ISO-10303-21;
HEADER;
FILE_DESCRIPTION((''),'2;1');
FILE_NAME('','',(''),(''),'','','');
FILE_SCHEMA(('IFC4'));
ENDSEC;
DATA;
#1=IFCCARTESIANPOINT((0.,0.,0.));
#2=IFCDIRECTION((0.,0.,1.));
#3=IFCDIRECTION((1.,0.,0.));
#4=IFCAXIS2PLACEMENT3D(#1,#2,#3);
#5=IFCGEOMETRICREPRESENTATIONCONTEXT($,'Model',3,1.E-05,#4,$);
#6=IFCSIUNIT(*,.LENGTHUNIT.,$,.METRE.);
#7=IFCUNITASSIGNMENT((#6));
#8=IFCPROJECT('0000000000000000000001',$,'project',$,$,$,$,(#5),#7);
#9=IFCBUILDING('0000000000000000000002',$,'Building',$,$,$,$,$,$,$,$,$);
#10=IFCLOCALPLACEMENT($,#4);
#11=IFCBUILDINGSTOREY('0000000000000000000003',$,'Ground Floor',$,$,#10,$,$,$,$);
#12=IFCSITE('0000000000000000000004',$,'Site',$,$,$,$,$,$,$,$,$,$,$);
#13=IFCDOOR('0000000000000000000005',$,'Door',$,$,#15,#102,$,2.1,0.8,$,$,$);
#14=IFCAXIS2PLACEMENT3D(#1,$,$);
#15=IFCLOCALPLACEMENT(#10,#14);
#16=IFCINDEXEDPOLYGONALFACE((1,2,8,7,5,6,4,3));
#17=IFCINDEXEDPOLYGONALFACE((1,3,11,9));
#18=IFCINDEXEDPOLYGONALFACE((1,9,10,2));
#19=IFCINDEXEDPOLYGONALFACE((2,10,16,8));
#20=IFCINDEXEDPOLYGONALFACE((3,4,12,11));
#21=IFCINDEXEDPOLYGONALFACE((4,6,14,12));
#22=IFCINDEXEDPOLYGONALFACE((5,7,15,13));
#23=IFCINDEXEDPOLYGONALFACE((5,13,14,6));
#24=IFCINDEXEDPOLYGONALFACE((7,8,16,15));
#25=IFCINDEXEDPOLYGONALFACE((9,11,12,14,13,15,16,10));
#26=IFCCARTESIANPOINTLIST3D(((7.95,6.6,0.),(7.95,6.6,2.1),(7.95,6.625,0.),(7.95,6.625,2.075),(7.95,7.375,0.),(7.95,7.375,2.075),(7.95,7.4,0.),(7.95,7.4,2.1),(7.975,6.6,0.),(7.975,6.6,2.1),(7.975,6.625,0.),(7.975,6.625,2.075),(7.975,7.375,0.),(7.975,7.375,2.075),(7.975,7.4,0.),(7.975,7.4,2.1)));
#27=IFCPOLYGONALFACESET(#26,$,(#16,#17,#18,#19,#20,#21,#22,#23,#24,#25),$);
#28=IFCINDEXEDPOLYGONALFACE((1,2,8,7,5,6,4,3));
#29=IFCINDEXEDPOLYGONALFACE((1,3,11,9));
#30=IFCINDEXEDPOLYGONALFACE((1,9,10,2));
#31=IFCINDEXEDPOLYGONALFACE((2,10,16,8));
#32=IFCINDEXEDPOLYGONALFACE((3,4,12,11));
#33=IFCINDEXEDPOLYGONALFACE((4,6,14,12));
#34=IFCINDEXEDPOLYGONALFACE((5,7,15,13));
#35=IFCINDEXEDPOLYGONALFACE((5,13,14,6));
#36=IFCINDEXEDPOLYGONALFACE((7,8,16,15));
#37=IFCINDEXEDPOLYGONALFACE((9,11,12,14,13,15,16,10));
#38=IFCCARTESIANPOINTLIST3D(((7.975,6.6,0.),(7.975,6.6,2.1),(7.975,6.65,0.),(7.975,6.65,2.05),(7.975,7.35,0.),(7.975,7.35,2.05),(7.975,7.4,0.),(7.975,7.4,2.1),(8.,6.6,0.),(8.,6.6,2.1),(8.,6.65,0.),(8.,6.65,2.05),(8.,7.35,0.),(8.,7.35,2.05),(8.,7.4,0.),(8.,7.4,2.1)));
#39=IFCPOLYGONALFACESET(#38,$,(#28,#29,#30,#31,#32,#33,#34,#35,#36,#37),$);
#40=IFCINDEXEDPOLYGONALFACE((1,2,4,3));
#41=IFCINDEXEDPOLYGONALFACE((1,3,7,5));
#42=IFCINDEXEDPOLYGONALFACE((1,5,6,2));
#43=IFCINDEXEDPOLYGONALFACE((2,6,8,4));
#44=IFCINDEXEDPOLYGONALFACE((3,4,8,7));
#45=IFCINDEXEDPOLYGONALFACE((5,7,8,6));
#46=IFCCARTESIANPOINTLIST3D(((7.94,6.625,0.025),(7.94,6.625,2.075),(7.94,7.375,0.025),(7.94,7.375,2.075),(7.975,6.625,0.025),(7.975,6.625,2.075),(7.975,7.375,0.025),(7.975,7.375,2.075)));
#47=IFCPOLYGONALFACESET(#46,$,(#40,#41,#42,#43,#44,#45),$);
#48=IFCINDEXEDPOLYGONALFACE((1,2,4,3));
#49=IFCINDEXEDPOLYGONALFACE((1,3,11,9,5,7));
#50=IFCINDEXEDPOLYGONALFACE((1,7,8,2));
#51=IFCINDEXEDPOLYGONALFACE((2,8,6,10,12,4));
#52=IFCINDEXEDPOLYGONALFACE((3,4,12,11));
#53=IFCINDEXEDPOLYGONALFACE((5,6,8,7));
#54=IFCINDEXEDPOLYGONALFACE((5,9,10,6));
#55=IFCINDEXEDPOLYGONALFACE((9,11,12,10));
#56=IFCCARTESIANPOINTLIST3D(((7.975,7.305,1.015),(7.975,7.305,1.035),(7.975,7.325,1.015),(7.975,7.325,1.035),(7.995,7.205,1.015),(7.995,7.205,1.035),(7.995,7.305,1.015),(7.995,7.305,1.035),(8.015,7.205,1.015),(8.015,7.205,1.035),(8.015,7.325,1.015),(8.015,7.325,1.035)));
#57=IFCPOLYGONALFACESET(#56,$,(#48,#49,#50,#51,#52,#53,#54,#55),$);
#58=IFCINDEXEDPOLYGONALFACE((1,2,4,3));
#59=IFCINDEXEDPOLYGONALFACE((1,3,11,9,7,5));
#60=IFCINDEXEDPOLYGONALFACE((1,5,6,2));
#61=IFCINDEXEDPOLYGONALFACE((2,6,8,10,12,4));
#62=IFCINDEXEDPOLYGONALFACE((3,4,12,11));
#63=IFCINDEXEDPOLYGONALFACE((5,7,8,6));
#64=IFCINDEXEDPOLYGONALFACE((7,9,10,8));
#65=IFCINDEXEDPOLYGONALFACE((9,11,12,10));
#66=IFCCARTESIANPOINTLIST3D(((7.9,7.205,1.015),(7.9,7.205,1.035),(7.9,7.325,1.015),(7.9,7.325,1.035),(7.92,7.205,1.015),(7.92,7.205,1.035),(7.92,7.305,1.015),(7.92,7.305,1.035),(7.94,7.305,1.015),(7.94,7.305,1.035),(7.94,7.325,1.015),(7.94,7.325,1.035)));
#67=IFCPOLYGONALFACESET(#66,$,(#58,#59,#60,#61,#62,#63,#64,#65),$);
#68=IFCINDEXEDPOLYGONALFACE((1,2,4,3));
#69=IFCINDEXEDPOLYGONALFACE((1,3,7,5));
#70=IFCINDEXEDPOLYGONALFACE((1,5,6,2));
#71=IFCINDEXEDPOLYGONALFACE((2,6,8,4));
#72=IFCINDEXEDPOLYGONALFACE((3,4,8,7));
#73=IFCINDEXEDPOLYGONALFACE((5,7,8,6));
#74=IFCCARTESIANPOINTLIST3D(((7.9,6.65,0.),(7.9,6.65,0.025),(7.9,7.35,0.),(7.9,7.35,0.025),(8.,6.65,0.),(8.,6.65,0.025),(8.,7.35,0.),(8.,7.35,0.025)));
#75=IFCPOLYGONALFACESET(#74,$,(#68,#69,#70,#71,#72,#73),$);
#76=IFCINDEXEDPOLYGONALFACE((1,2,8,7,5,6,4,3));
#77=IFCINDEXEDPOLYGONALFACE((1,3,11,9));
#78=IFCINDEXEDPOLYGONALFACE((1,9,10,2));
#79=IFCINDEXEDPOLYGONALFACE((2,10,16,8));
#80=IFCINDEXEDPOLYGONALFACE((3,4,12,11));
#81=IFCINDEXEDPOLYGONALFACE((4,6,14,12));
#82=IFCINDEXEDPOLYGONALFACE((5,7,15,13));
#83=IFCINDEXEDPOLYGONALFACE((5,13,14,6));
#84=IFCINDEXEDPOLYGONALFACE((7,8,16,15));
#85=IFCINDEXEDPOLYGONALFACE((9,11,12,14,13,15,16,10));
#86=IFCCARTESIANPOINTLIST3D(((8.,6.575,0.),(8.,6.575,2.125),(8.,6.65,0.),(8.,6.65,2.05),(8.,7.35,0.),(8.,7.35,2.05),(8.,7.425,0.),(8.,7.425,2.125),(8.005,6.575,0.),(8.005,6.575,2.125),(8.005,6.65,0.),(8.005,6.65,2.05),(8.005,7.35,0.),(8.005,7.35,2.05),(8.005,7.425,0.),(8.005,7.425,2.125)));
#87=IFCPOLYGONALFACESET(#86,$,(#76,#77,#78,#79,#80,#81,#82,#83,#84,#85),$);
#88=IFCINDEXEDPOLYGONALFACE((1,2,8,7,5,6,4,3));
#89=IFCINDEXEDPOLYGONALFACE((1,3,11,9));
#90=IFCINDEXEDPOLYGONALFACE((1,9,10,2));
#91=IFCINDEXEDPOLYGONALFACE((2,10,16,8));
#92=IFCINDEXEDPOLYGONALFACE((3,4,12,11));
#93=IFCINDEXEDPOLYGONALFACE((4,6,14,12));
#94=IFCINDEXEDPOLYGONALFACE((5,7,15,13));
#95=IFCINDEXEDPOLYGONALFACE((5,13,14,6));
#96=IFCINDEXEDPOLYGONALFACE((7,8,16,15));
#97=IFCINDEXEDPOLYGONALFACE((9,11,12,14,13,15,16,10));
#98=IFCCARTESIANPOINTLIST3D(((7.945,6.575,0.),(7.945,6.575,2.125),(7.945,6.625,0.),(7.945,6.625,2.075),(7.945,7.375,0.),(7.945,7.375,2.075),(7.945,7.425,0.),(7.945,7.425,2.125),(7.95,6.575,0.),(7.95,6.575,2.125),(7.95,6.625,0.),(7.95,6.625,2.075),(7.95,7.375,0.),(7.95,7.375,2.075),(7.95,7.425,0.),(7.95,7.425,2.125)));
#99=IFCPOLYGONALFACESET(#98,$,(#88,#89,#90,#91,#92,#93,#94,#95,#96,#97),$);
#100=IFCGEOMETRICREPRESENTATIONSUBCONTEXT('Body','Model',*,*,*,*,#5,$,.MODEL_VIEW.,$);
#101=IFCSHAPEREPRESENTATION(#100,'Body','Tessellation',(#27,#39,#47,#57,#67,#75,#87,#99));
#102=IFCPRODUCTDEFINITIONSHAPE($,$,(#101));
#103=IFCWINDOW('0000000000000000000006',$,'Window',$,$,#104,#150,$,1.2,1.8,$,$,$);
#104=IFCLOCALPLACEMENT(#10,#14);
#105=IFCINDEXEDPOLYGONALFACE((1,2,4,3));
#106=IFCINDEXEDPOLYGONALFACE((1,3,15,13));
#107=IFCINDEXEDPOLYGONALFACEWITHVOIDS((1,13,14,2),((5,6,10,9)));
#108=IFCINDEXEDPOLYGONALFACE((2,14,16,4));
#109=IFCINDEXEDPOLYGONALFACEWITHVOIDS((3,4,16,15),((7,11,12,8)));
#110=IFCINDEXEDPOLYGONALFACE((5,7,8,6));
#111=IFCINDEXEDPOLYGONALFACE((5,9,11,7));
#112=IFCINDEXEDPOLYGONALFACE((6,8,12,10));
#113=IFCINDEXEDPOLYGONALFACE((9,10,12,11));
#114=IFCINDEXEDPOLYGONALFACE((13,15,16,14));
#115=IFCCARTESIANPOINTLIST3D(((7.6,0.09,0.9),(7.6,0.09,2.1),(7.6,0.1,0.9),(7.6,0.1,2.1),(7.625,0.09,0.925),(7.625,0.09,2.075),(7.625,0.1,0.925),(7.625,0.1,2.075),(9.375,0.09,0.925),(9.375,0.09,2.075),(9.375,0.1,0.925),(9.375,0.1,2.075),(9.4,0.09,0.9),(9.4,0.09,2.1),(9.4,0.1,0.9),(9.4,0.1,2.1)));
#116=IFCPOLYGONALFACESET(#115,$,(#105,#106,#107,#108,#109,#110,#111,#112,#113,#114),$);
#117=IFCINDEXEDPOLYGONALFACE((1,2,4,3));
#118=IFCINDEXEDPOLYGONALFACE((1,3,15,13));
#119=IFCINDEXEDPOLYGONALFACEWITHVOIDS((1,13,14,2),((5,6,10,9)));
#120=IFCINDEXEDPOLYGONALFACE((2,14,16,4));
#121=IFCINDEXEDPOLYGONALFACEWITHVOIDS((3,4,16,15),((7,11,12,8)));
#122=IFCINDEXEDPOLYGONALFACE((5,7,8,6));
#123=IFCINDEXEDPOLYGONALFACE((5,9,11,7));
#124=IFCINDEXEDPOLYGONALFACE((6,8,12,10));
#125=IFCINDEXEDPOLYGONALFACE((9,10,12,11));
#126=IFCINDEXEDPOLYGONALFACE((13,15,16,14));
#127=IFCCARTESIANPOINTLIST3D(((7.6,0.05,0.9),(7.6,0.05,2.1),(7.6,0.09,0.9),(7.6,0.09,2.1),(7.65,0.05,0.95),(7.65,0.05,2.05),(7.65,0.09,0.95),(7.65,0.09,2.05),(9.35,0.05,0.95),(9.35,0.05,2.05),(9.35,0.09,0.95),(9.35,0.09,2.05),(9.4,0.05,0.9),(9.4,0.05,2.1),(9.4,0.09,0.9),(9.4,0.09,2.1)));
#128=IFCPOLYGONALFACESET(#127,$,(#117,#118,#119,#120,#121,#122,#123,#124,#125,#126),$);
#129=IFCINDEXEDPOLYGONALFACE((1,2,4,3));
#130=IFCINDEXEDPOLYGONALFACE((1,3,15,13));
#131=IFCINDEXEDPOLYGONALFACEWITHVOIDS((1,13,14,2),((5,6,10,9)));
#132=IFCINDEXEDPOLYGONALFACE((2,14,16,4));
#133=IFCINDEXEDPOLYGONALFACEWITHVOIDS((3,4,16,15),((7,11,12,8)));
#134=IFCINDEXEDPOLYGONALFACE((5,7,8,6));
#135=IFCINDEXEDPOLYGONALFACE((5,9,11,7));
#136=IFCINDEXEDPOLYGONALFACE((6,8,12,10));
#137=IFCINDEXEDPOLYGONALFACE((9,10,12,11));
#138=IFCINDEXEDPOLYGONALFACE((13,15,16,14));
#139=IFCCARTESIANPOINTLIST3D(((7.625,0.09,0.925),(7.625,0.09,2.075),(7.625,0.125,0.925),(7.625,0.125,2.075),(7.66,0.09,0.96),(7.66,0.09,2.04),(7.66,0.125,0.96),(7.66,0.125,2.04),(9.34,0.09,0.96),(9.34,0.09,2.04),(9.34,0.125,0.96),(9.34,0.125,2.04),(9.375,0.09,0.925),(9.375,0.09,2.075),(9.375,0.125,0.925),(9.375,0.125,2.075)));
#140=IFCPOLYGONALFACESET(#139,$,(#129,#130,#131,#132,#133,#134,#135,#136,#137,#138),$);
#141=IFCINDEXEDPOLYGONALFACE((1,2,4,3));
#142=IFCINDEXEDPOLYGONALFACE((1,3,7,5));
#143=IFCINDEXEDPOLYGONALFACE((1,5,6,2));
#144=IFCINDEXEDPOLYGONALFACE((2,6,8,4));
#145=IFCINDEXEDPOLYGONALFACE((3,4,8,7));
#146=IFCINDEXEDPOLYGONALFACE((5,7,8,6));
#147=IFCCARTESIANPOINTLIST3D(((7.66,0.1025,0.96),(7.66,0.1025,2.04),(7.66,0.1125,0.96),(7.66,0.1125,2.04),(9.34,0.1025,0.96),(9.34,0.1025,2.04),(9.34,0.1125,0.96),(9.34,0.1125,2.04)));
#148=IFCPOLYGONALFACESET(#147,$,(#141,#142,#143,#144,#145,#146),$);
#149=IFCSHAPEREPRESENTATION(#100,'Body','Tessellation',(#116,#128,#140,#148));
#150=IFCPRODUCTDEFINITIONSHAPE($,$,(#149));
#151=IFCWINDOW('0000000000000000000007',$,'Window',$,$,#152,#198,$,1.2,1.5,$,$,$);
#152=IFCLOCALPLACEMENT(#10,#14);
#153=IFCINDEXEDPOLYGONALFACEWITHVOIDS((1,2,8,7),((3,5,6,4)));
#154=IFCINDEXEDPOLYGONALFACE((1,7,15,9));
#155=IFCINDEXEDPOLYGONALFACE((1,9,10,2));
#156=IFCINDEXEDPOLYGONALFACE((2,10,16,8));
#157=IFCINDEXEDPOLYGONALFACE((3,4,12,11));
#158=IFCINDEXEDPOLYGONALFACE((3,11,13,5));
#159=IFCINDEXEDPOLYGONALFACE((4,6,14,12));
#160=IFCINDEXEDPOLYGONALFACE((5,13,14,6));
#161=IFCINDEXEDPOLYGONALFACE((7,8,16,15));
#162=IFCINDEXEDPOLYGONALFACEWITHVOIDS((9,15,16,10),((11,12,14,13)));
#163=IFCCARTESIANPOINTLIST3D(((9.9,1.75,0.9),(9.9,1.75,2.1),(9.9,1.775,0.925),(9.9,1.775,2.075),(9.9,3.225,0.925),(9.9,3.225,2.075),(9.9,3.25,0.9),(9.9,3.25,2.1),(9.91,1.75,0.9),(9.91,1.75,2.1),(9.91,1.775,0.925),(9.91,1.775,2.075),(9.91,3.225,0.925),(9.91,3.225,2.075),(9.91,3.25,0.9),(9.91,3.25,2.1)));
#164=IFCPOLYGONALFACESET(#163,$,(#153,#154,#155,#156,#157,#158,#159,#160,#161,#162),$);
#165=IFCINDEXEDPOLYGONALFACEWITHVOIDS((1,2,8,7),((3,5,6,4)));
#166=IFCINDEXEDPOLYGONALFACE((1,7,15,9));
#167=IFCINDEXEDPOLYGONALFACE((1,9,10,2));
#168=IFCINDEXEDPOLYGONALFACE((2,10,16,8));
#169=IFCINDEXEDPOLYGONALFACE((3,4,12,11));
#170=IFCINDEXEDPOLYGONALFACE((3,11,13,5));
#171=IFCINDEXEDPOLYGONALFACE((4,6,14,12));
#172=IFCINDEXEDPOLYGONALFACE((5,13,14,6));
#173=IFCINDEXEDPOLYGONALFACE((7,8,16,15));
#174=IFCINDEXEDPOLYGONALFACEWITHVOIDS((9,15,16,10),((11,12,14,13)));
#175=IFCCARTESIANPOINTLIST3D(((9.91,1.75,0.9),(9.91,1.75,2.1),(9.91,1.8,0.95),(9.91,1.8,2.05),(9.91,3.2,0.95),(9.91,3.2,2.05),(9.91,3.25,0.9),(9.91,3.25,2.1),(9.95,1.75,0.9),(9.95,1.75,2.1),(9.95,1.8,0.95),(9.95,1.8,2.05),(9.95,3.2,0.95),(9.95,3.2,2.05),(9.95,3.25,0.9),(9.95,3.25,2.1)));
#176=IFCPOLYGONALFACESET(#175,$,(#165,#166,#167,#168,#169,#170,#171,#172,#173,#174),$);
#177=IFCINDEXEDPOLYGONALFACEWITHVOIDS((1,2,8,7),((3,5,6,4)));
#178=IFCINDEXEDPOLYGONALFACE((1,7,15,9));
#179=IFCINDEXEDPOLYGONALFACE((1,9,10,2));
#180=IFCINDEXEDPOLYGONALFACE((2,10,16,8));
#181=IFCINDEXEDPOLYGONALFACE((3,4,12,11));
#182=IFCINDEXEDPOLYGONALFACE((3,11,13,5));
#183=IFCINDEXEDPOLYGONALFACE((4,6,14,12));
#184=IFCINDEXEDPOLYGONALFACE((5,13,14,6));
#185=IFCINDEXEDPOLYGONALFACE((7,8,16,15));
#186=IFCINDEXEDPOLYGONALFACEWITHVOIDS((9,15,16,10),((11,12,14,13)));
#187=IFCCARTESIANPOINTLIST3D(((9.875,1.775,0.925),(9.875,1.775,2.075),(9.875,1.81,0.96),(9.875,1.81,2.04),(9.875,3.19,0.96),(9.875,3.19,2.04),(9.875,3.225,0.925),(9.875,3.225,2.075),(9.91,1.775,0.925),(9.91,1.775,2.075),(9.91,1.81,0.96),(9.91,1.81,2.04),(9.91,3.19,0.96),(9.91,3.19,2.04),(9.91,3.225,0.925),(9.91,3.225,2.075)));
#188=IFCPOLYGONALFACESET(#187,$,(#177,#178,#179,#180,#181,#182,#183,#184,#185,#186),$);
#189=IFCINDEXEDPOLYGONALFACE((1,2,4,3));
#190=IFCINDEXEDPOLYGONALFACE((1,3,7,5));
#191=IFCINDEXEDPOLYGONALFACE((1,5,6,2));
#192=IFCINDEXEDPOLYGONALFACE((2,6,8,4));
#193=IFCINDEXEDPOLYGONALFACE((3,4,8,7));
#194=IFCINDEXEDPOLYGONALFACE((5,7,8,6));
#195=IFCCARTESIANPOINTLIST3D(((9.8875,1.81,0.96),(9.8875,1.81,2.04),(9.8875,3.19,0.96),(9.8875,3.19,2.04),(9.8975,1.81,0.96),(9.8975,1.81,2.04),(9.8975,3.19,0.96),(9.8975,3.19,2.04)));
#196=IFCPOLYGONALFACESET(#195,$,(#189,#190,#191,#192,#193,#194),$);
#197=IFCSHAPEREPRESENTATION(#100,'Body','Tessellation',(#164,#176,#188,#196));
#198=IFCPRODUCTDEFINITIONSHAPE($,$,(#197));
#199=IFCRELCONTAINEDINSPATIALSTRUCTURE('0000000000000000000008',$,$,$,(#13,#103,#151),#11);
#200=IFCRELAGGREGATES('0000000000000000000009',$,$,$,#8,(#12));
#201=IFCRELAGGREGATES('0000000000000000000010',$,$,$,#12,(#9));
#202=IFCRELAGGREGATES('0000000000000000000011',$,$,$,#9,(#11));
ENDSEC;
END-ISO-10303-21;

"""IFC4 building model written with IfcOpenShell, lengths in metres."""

from ifc_helpers import new_model, si_unit, frame, origin_with_axes, place, context, subcontext, project, spatial, line, indexed_curve, outline, extrude, element, save


model = new_model("IFC4")

# Units and contexts
model_context = context("Model", 3, precision=1e-05, world=origin_with_axes())
body_context = subcontext(model_context, "Body", "Model", "MODEL_VIEW")
ifc_project = project(units=[si_unit("LENGTHUNIT", "METRE")], contexts=[model_context])

# Site, building, storey
site = spatial("IfcSite", under=ifc_project, Name="Site")
building = spatial("IfcBuilding", under=site, Name="Building")
storey_placement = place(None, origin_with_axes())
storey = spatial("IfcBuildingStorey", under=building, at=storey_placement, Name="Ground Floor")

# Door
door_1_placement = place(storey_placement, frame((8.0, 6.6, 0.0), z_axis=(0.0, 0.0, 1.0), x_axis=(0.0, 1.0, 0.0)))
element("IfcDoor", 1, at=door_1_placement, inside=storey, Name="Door", OverallHeight=2.1, OverallWidth=0.8, context=body_context, shape_type="SweptSolid", body=[
    extrude(outline(indexed_curve([(0.0, 0.0), (0.0, 2.1), (0.8, 2.1), (0.8, 0.0), (0.775, 0.0), (0.775, 2.075), (0.025, 2.075), (0.025, 0.0)], segments=[line(1, 2, 3, 4, 5, 6, 7, 8, 1)])), frame((0.0, 0.025, 0.0), z_axis=(0.0, -1.0, 0.0), x_axis=(1.0, 0.0, 0.0)), (0.0, 0.0, -1.0), 0.025),
    extrude(outline(indexed_curve([(0.0, 0.0), (0.0, 2.1), (0.8, 2.1), (0.8, 0.0), (0.75, 0.0), (0.75, 2.05), (0.05, 2.05), (0.05, 0.0)], segments=[line(1, 2, 3, 4, 5, 6, 7, 8, 1)])), frame((0.0, 0.0, 0.0), z_axis=(0.0, -1.0, 0.0), x_axis=(1.0, 0.0, 0.0)), (0.0, 0.0, -1.0), 0.025),
    extrude(outline(indexed_curve([(0.0, 0.0), (0.75, 0.0), (0.75, 0.035), (0.0, 0.035)], segments=[line(1, 2, 3, 4, 1)])), frame((0.025, 0.025, 0.025), z_axis=(0.0, 0.0, 1.0), x_axis=(1.0, 0.0, 0.0)), (0.0, 0.0, 1.0), 2.05),
    extrude(outline(indexed_curve([(0.0, 0.0), (0.0, -0.04), (-0.12, -0.04), (-0.12, -0.02), (-0.02, -0.02), (-0.02, 0.0)], segments=[line(1, 2, 3, 4, 5, 6, 1)])), frame((0.725, 0.025, 1.015), z_axis=(0.0, 0.0, 1.0), x_axis=(1.0, 0.0, 0.0)), (0.0, 0.0, 1.0), 0.02),
    extrude(outline(indexed_curve([(0.0, 0.0), (0.0, 0.04), (-0.12, 0.04), (-0.12, 0.02), (-0.02, 0.02), (-0.02, 0.0)], segments=[line(1, 2, 3, 4, 5, 6, 1)])), frame((0.725, 0.06, 1.015), z_axis=(0.0, 0.0, 1.0), x_axis=(1.0, 0.0, 0.0)), (0.0, 0.0, 1.0), 0.02),
    extrude(outline(indexed_curve([(0.0, 0.0), (0.7, 0.0), (0.7, 0.1), (0.0, 0.1)], segments=[line(1, 2, 3, 4, 1)])), frame((0.05, 0.0, 0.0), z_axis=(0.0, 0.0, 1.0), x_axis=(1.0, 0.0, 0.0)), (0.0, 0.0, 1.0), 0.025),
    extrude(outline(indexed_curve([(0.0, 0.0), (0.0, 2.125), (0.85, 2.125), (0.85, 0.0), (0.775, 0.0), (0.775, 2.05), (0.075, 2.05), (0.075, 0.0)], segments=[line(1, 2, 3, 4, 5, 6, 7, 8, 1)])), frame((-0.025, -0.005, 0.0), z_axis=(0.0, -1.0, 0.0), x_axis=(1.0, 0.0, 0.0)), (0.0, 0.0, -1.0), 0.005),
    extrude(outline(indexed_curve([(0.0, 0.0), (0.0, 2.125), (0.85, 2.125), (0.85, 0.0), (0.8, 0.0), (0.8, 2.075), (0.05, 2.075), (0.05, 0.0)], segments=[line(1, 2, 3, 4, 5, 6, 7, 8, 1)])), frame((-0.025, 0.05, 0.0), z_axis=(0.0, -1.0, 0.0), x_axis=(1.0, 0.0, 0.0)), (0.0, 0.0, -1.0), 0.005),
])

# Windows
window_1_placement = place(storey_placement, frame((7.6, 0.0, 0.9), z_axis=(0.0, 0.0, 1.0), x_axis=(1.0, 0.0, 0.0)))
element("IfcWindow", 2, at=window_1_placement, inside=storey, Name="Window", OverallHeight=1.2, OverallWidth=1.8, context=body_context, shape_type="SweptSolid", body=[
    extrude(outline(indexed_curve([(0.0, 0.0), (1.8, 0.0), (1.8, 1.2), (0.0, 1.2)], segments=[line(1, 2, 3, 4, 1)]), holes=[indexed_curve([(0.025, 0.025), (1.775, 0.025), (1.775, 1.175), (0.025, 1.175)], segments=[line(1, 2, 3, 4, 1)])]), frame((0.0, 0.09, 0.0), z_axis=(0.0, -1.0, 0.0), x_axis=(1.0, 0.0, 0.0)), (0.0, 0.0, -1.0), 0.01),
    extrude(outline(indexed_curve([(0.0, 0.0), (1.8, 0.0), (1.8, 1.2), (0.0, 1.2)], segments=[line(1, 2, 3, 4, 1)]), holes=[indexed_curve([(0.05, 0.05), (1.75, 0.05), (1.75, 1.15), (0.05, 1.15)], segments=[line(1, 2, 3, 4, 1)])]), frame((0.0, 0.05, 0.0), z_axis=(0.0, -1.0, 0.0), x_axis=(1.0, 0.0, 0.0)), (0.0, 0.0, -1.0), 0.04),
    extrude(outline(indexed_curve([(0.0, 0.0), (1.75, 0.0), (1.75, 1.15), (0.0, 1.15)], segments=[line(1, 2, 3, 4, 1)]), holes=[indexed_curve([(0.035, 0.035), (1.715, 0.035), (1.715, 1.115), (0.035, 1.115)], segments=[line(1, 2, 3, 4, 1)])]), frame((0.025, 0.09, 0.025), z_axis=(0.0, -1.0, 0.0), x_axis=(1.0, 0.0, 0.0)), (0.0, 0.0, -1.0), 0.035),
    extrude(outline(indexed_curve([(0.035, 0.035), (1.715, 0.035), (1.715, 1.115), (0.035, 1.115)], segments=[line(1, 2, 3, 4, 1)])), frame((0.025, 0.1025, 0.025), z_axis=(0.0, -1.0, 0.0), x_axis=(1.0, 0.0, 0.0)), (0.0, 0.0, -1.0), 0.01),
])
window_2_placement = place(storey_placement, frame((10.0, 1.75, 0.9), z_axis=(0.0, 0.0, 1.0), x_axis=(0.0, 1.0, 0.0)))
element("IfcWindow", 3, at=window_2_placement, inside=storey, Name="Window", OverallHeight=1.2, OverallWidth=1.5, context=body_context, shape_type="SweptSolid", body=[
    extrude(outline(indexed_curve([(0.0, 0.0), (1.5, 0.0), (1.5, 1.2), (0.0, 1.2)], segments=[line(1, 2, 3, 4, 1)]), holes=[indexed_curve([(0.025, 0.025), (1.475, 0.025), (1.475, 1.175), (0.025, 1.175)], segments=[line(1, 2, 3, 4, 1)])]), frame((0.0, 0.09, 0.0), z_axis=(0.0, -1.0, 0.0), x_axis=(1.0, 0.0, 0.0)), (0.0, 0.0, -1.0), 0.01),
    extrude(outline(indexed_curve([(0.0, 0.0), (1.5, 0.0), (1.5, 1.2), (0.0, 1.2)], segments=[line(1, 2, 3, 4, 1)]), holes=[indexed_curve([(0.05, 0.05), (1.45, 0.05), (1.45, 1.15), (0.05, 1.15)], segments=[line(1, 2, 3, 4, 1)])]), frame((0.0, 0.05, 0.0), z_axis=(0.0, -1.0, 0.0), x_axis=(1.0, 0.0, 0.0)), (0.0, 0.0, -1.0), 0.04),
    extrude(outline(indexed_curve([(0.0, 0.0), (1.45, 0.0), (1.45, 1.15), (0.0, 1.15)], segments=[line(1, 2, 3, 4, 1)]), holes=[indexed_curve([(0.035, 0.035), (1.415, 0.035), (1.415, 1.115), (0.035, 1.115)], segments=[line(1, 2, 3, 4, 1)])]), frame((0.025, 0.09, 0.025), z_axis=(0.0, -1.0, 0.0), x_axis=(1.0, 0.0, 0.0)), (0.0, 0.0, -1.0), 0.035),
    extrude(outline(indexed_curve([(0.035, 0.035), (1.415, 0.035), (1.415, 1.115), (0.035, 1.115)], segments=[line(1, 2, 3, 4, 1)])), frame((0.025, 0.1025, 0.025), z_axis=(0.0, -1.0, 0.0), x_axis=(1.0, 0.0, 0.0)), (0.0, 0.0, -1.0), 0.01),
])

save(model, "model.ifc")
